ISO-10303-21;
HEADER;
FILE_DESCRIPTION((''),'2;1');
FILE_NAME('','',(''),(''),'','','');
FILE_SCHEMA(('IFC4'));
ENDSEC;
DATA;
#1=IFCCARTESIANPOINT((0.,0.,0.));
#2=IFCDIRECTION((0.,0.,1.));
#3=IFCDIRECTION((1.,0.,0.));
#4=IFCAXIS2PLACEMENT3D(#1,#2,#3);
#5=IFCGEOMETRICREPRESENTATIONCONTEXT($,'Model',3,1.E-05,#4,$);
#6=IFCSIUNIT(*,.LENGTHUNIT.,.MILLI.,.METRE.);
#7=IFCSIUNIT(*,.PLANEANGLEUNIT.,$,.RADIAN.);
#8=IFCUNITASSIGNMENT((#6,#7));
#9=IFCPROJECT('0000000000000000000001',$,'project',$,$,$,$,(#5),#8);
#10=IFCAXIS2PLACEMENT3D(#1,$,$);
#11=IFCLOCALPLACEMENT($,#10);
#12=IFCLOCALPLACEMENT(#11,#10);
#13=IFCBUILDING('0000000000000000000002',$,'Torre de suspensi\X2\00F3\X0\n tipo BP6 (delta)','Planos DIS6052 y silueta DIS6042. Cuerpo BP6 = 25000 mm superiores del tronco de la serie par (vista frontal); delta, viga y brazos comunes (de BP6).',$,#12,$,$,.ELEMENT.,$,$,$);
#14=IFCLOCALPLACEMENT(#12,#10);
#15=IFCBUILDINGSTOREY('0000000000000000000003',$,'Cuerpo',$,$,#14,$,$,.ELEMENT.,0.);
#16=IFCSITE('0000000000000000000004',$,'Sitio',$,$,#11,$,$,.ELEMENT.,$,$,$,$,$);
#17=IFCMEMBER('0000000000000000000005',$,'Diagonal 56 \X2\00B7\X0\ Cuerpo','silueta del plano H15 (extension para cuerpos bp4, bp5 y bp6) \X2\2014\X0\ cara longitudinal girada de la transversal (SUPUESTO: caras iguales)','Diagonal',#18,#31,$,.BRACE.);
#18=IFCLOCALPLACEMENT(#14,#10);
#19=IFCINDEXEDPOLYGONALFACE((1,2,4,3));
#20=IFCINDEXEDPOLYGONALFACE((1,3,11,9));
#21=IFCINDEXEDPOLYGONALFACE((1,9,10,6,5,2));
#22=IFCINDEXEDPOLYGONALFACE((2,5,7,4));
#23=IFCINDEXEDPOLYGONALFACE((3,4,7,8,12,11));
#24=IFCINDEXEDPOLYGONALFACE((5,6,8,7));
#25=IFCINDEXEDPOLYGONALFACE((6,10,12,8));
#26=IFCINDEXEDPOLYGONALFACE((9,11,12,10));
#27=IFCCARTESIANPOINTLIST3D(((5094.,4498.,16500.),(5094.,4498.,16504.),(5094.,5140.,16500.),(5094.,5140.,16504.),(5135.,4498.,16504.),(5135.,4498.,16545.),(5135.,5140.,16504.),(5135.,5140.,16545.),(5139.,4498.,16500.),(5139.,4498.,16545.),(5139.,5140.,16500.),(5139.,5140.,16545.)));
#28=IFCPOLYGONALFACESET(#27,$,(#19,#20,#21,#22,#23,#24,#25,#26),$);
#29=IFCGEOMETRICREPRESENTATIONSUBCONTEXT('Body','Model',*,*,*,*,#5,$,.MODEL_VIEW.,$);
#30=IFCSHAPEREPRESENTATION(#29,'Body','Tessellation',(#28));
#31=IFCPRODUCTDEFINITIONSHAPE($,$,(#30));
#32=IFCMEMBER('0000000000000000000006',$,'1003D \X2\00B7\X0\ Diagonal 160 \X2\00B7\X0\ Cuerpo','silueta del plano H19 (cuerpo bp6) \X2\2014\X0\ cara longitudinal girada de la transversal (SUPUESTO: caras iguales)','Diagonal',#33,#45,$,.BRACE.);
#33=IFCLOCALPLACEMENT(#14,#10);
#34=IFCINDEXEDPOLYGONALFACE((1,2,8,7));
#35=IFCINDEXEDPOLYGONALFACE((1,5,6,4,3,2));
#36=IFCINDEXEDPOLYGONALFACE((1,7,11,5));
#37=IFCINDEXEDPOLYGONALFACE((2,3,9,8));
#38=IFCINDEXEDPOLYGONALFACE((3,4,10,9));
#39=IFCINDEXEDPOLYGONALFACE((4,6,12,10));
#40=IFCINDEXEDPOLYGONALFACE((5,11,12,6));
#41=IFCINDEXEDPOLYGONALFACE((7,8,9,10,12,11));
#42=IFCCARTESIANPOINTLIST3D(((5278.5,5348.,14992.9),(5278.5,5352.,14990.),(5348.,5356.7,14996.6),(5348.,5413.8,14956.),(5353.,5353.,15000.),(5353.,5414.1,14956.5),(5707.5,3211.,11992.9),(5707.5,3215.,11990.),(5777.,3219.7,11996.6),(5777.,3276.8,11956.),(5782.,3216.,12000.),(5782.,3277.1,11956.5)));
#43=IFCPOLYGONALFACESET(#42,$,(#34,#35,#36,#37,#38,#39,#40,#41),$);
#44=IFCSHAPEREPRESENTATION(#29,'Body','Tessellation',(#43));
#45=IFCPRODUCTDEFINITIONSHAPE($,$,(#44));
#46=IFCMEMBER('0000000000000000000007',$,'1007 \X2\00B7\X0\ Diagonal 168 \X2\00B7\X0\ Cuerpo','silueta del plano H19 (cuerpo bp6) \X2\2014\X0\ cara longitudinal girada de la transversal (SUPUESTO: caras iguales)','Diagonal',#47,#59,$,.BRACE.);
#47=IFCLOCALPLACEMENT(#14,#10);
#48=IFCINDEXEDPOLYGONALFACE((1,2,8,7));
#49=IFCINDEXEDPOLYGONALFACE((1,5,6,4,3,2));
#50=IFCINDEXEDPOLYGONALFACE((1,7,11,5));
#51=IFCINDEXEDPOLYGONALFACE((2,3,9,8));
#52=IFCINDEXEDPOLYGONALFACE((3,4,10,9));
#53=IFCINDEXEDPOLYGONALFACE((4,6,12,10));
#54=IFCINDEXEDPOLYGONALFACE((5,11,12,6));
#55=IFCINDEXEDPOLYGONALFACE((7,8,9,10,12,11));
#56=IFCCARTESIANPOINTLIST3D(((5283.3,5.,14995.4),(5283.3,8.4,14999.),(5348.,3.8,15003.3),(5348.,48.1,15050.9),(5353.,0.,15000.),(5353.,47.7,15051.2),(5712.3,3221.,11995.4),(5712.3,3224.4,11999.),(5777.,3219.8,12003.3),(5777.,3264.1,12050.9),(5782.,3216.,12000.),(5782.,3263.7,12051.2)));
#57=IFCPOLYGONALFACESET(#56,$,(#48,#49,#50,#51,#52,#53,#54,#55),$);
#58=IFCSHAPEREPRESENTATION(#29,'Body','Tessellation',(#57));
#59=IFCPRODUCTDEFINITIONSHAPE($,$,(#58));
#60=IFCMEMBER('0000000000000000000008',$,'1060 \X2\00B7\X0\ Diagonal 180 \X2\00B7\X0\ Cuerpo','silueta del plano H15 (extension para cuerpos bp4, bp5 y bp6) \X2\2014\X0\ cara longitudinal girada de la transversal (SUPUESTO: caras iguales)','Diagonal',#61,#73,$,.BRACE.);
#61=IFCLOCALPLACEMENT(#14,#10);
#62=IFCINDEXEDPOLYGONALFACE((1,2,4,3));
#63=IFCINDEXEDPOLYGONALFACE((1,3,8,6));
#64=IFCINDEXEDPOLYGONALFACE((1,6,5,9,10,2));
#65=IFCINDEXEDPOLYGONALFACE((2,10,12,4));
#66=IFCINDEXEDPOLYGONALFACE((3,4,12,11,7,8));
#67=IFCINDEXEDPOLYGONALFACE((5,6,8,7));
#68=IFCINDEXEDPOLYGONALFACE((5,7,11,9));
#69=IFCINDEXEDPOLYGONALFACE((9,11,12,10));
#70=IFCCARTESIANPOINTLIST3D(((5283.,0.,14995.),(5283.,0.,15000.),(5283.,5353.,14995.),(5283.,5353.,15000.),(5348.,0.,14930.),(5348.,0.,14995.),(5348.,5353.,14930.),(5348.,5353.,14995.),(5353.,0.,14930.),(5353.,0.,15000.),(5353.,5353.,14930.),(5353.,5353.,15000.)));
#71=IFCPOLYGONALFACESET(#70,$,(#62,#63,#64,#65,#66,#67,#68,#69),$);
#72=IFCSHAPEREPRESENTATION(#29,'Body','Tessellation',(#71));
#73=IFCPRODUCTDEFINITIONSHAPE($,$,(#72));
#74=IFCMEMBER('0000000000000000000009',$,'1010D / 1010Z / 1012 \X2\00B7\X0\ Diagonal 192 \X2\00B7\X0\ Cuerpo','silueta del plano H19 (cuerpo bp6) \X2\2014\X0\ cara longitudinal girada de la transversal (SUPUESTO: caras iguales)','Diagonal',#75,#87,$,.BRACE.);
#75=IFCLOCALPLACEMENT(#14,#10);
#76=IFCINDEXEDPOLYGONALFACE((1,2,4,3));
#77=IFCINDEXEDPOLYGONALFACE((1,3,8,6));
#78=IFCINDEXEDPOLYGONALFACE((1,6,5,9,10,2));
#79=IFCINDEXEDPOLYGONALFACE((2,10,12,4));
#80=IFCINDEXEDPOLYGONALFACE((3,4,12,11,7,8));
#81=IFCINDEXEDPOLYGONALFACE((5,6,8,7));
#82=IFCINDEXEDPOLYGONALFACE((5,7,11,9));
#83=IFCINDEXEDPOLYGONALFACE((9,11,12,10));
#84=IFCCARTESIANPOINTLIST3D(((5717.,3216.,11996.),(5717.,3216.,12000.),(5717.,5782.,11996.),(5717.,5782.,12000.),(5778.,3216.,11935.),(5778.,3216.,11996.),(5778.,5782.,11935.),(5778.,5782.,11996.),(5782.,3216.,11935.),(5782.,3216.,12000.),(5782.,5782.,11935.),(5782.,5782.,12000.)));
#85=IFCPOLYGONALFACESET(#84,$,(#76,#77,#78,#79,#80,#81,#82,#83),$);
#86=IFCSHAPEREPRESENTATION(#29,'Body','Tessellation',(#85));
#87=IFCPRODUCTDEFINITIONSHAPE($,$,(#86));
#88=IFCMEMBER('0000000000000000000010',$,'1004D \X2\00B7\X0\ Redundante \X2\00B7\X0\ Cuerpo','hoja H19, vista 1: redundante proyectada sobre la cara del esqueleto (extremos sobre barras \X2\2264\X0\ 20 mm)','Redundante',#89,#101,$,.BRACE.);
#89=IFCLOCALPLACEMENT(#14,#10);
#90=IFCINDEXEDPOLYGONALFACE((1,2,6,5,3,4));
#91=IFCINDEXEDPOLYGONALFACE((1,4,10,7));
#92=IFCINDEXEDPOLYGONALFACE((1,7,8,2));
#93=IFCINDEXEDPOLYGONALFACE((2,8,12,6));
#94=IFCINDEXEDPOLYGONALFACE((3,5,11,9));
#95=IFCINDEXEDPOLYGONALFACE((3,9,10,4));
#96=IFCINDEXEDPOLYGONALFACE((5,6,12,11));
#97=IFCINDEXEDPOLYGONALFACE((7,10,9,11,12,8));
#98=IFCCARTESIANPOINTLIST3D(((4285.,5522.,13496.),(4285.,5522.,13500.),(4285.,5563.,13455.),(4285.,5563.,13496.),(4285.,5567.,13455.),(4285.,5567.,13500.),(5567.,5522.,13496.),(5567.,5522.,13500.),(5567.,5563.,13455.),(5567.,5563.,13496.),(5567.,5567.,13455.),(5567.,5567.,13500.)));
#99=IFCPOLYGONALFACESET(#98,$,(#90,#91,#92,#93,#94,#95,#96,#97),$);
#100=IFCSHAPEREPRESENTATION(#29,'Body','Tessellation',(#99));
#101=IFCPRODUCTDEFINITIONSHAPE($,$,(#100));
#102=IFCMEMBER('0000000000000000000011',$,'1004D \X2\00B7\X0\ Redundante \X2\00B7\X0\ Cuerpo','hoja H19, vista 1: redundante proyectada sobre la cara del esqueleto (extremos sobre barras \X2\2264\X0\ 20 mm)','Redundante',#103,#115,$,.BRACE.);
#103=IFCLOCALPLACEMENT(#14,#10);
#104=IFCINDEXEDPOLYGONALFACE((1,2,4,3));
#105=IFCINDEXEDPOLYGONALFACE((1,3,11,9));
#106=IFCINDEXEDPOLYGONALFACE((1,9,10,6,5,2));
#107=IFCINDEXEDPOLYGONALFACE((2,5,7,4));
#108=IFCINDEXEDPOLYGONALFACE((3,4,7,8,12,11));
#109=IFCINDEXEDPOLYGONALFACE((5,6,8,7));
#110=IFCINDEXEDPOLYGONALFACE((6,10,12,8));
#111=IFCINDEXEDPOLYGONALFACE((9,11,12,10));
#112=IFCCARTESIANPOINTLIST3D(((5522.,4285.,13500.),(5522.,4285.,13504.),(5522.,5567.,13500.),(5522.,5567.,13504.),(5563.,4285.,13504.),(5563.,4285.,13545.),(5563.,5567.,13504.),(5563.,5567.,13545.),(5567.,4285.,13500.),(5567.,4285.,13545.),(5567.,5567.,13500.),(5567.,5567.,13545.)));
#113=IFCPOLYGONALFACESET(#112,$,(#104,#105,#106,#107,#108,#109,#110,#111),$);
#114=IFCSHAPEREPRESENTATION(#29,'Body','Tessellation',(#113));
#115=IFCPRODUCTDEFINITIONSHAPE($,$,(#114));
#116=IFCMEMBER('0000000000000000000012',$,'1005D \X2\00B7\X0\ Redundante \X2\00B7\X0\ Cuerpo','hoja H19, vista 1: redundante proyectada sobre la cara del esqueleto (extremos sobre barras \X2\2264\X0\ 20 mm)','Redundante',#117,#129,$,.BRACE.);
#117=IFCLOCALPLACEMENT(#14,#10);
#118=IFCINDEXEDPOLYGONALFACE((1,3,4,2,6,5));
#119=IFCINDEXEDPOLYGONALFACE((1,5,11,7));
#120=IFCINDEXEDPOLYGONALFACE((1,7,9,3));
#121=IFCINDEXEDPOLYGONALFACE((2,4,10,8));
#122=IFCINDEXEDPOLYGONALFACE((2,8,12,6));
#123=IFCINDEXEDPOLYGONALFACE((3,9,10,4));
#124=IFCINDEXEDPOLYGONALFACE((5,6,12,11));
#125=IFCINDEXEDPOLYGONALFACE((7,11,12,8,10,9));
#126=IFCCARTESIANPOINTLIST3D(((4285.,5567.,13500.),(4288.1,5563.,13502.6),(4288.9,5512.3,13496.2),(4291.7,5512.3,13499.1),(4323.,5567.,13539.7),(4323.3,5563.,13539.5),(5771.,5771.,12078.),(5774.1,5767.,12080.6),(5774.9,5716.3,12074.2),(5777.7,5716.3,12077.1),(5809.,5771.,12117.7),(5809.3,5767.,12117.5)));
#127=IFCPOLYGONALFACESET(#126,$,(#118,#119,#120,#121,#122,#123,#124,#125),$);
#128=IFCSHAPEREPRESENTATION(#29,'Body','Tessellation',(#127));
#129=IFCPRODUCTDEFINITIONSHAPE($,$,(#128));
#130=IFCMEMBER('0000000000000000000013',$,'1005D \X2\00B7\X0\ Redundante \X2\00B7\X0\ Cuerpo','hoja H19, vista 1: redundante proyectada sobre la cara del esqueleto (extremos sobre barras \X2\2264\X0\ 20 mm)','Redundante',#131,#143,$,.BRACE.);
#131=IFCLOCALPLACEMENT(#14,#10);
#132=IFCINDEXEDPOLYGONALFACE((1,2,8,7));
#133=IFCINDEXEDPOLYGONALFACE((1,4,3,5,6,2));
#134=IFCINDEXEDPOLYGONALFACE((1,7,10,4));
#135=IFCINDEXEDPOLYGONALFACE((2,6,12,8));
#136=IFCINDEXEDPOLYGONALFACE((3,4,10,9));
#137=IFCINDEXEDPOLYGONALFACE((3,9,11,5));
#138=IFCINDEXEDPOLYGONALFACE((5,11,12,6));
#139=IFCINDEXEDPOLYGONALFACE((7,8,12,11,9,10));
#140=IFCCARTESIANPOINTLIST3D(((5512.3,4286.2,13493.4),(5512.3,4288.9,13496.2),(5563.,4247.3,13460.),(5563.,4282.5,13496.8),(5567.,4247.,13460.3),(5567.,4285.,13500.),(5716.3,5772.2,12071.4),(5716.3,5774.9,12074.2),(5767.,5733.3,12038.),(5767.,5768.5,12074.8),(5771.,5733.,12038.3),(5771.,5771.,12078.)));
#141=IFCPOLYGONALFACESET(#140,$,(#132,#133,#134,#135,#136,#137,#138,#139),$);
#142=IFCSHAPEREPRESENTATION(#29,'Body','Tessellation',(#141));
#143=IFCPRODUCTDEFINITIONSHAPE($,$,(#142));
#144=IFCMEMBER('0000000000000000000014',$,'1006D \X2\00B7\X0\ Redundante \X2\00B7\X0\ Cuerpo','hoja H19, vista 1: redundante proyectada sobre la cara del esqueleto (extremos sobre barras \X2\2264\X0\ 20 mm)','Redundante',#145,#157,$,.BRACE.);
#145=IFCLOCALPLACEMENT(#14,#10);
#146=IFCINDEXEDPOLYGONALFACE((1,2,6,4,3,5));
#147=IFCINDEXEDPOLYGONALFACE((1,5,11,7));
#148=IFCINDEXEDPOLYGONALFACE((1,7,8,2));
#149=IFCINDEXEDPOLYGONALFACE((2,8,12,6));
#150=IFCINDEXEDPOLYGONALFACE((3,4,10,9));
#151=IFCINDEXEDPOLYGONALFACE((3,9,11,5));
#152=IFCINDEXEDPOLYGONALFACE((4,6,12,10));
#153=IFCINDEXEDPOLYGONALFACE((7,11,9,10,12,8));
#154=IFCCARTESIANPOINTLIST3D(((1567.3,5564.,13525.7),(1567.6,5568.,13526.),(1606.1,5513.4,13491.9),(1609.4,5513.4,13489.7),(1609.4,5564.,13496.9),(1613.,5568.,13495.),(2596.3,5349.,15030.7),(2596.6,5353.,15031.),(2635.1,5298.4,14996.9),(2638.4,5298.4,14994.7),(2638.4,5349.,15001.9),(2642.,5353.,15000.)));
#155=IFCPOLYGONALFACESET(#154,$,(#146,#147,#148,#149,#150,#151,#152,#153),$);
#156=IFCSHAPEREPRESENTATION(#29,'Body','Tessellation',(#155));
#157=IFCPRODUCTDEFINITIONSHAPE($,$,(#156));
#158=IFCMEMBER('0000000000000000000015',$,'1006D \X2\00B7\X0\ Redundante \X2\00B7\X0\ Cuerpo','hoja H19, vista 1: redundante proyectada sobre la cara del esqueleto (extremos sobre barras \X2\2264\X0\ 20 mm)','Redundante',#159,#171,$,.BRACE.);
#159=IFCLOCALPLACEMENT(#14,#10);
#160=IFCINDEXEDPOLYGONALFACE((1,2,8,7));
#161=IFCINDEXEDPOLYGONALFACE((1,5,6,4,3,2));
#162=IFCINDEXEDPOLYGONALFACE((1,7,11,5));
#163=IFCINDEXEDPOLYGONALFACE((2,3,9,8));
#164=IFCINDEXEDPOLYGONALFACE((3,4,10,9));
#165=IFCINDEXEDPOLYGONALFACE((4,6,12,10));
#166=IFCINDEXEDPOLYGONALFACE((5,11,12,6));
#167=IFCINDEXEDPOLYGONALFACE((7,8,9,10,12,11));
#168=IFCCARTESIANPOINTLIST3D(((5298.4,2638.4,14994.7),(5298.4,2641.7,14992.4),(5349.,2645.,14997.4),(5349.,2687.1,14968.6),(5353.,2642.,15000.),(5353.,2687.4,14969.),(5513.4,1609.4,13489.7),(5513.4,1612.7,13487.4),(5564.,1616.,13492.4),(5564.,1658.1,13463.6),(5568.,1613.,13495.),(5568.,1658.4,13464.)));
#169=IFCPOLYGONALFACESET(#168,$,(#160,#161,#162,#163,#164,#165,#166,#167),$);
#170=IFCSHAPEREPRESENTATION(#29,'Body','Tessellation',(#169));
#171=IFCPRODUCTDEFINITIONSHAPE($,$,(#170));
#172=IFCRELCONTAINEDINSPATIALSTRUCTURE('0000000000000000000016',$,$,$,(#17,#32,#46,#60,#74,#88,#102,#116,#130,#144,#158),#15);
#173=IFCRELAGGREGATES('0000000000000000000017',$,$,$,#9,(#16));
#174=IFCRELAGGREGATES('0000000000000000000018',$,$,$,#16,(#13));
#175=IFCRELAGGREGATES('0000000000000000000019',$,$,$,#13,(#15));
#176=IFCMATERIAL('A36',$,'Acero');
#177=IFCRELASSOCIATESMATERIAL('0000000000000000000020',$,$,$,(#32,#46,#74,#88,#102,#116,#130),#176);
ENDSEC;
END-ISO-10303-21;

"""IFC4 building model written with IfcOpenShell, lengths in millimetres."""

from ifc_helpers import new_model, si_unit, frame, frame_2d, origin, origin_with_axes, place, context, subcontext, project, spatial, l_section, extrude, material, element, save


model = new_model("IFC4")

# Units and contexts
model_context = context("Model", 3, precision=1e-05, world=origin_with_axes())
body_context = subcontext(model_context, "Body", "Model", "MODEL_VIEW")
ifc_project = project(units=[si_unit("LENGTHUNIT", "METRE", prefix="MILLI"), si_unit("PLANEANGLEUNIT", "RADIAN")], contexts=[model_context])

# Site, building, storey
site_placement = place(None, origin())
site = spatial("IfcSite", under=ifc_project, at=site_placement, Name="Sitio", CompositionType="ELEMENT")
building_placement = place(site_placement, origin())
building = spatial("IfcBuilding", under=site, at=building_placement, Name="Torre de suspensión tipo BP6 (delta)", Description="Planos DIS6052 y silueta DIS6042. Cuerpo BP6 = 25000 mm superiores del tronco de la serie par (vista frontal); delta, viga y brazos comunes (de BP6).", CompositionType="ELEMENT")
storey_placement = place(building_placement, origin())
storey = spatial("IfcBuildingStorey", under=building, at=storey_placement, Name="Cuerpo", CompositionType="ELEMENT", Elevation=0.0)

# Members
ifc_material_1 = material(Name="A36", Category="Acero")
member_1_placement = place(storey_placement, frame((5139.0, 4498.0, 16500.0), z_axis=(0.0, 1.0, 0.0), x_axis=(-1.0, 0.0, 0.0)))
element("IfcMember", 1, at=member_1_placement, inside=storey, Name="Diagonal 56 · Cuerpo", Description="silueta del plano H15 (extension para cuerpos bp4, bp5 y bp6) — cara longitudinal girada de la transversal (SUPUESTO: caras iguales)", ObjectType="Diagonal", PredefinedType="BRACE", context=body_context, shape_type="SweptSolid", body=[
    extrude(l_section(Depth=45.0, Width=45.0, Thickness=4.0, at=frame_2d((22.5, 22.5))), None, (0.0, 0.0, 1.0), 642.0),
])
member_2_placement = place(storey_placement, frame((5353.0, 5353.0, 15000.0), z_axis=(0.115689, -0.576289, -0.809016), x_axis=(-0.993285, -0.067121, -0.094227)))
element("IfcMember", 2, at=member_2_placement, inside=storey, material=ifc_material_1, Name="1003D · Diagonal 160 · Cuerpo", Description="silueta del plano H19 (cuerpo bp6) — cara longitudinal girada de la transversal (SUPUESTO: caras iguales)", ObjectType="Diagonal", PredefinedType="BRACE", context=body_context, shape_type="SweptSolid", body=[
    extrude(l_section(Depth=75.0, Width=75.0, Thickness=5.0, at=frame_2d((37.5, 37.5))), None, (0.0, 0.0, 1.0), 3708.2),
])
member_3_placement = place(storey_placement, frame((5353.0, 0.0, 15000.0), z_axis=(0.097083, 0.727783, -0.678902), x_axis=(-0.995276, 0.070991, -0.066223)))
element("IfcMember", 3, at=member_3_placement, inside=storey, material=ifc_material_1, Name="1007 · Diagonal 168 · Cuerpo", Description="silueta del plano H19 (cuerpo bp6) — cara longitudinal girada de la transversal (SUPUESTO: caras iguales)", ObjectType="Diagonal", PredefinedType="BRACE", context=body_context, shape_type="SweptSolid", body=[
    extrude(l_section(Depth=70.0, Width=70.0, Thickness=5.0, at=frame_2d((35.0, 35.0))), None, (0.0, 0.0, 1.0), 4418.9),
])
member_4_placement = place(storey_placement, frame((5353.0, 5353.0, 15000.0), z_axis=(0.0, -1.0, 0.0), x_axis=(-1.0, 0.0, 0.0)))
element("IfcMember", 4, at=member_4_placement, inside=storey, Name="1060 · Diagonal 180 · Cuerpo", Description="silueta del plano H15 (extension para cuerpos bp4, bp5 y bp6) — cara longitudinal girada de la transversal (SUPUESTO: caras iguales)", ObjectType="Diagonal", PredefinedType="BRACE", context=body_context, shape_type="SweptSolid", body=[
    extrude(l_section(Depth=70.0, Width=70.0, Thickness=5.0, at=frame_2d((35.0, 35.0))), None, (0.0, 0.0, 1.0), 5353.0),
])
member_5_placement = place(storey_placement, frame((5782.0, 5782.0, 12000.0), z_axis=(0.0, -1.0, 0.0), x_axis=(-1.0, 0.0, 0.0)))
element("IfcMember", 5, at=member_5_placement, inside=storey, material=ifc_material_1, Name="1010D / 1010Z / 1012 · Diagonal 192 · Cuerpo", Description="silueta del plano H19 (cuerpo bp6) — cara longitudinal girada de la transversal (SUPUESTO: caras iguales)", ObjectType="Diagonal", PredefinedType="BRACE", context=body_context, shape_type="SweptSolid", body=[
    extrude(l_section(Depth=65.0, Width=65.0, Thickness=4.0, at=frame_2d((32.5, 32.5))), None, (0.0, 0.0, 1.0), 2566.0),
])
for number, where, z_axis, x_axis, name in (
    (6, (4285.0, 5567.0, 13500.0), (1.0, 0.0, 0.0), (0.0, -1.0, 0.0), "1004D · Redundante · Cuerpo"),
    (7, (5567.0, 4285.0, 13500.0), (0.0, 1.0, 0.0), (-1.0, 0.0, 0.0), "1004D · Redundante · Cuerpo"),
):
    element("IfcMember", number, at=place(storey_placement, frame(where, z_axis=z_axis, x_axis=x_axis)), inside=storey, material=ifc_material_1, Name=name, Description="hoja H19, vista 1: redundante proyectada sobre la cara del esqueleto (extremos sobre barras ≤ 20 mm)", ObjectType="Redundante", PredefinedType="BRACE", context=body_context, shape_type="SweptSolid", body=[
        extrude(l_section(Depth=45.0, Width=45.0, Thickness=4.0, at=frame_2d((22.5, 22.5))), None, (0.0, 0.0, 1.0), 1282.0),
    ])
for number, where, z_axis, x_axis, name in (
    (8, (5771.0, 5771.0, 12078.0), (-0.718966, -0.098701, 0.688001), (0.071311, -0.995117, -0.068239), "1005D · Redundante · Cuerpo"),
    (9, (5771.0, 5771.0, 12078.0), (-0.098701, -0.718966, 0.688001), (-0.995117, 0.071311, -0.068239), "1005D · Redundante · Cuerpo"),
):
    element("IfcMember", number, at=place(storey_placement, frame(where, z_axis=z_axis, x_axis=x_axis)), inside=storey, material=ifc_material_1, Name=name, Description="hoja H19, vista 1: redundante proyectada sobre la cara del esqueleto (extremos sobre barras ≤ 20 mm)", ObjectType="Redundante", PredefinedType="BRACE", context=body_context, shape_type="SweptSolid", body=[
        extrude(l_section(Depth=55.0, Width=55.0, Thickness=4.0, at=frame_2d((27.5, 27.5))), None, (0.0, 0.0, 1.0), 2066.9),
    ])
for number, where, z_axis, x_axis, name in (
    (10, (2642.0, 5353.0, 15000.0), (-0.560524, 0.117116, -0.819815), (-0.066101, -0.993118, -0.096679), "1006D · Redundante · Cuerpo"),
    (11, (5353.0, 2642.0, 15000.0), (0.117116, -0.560524, -0.819815), (-0.993118, -0.066101, -0.096679), "1006D · Redundante · Cuerpo"),
):
    element("IfcMember", number, at=place(storey_placement, frame(where, z_axis=z_axis, x_axis=x_axis)), inside=storey, Name=name, Description="hoja H19, vista 1: redundante proyectada sobre la cara del esqueleto (extremos sobre barras ≤ 20 mm)", ObjectType="Redundante", PredefinedType="BRACE", context=body_context, shape_type="SweptSolid", body=[
        extrude(l_section(Depth=55.0, Width=55.0, Thickness=4.0, at=frame_2d((27.5, 27.5))), None, (0.0, 0.0, 1.0), 1835.8),
    ])

save(model, "model.ifc")
